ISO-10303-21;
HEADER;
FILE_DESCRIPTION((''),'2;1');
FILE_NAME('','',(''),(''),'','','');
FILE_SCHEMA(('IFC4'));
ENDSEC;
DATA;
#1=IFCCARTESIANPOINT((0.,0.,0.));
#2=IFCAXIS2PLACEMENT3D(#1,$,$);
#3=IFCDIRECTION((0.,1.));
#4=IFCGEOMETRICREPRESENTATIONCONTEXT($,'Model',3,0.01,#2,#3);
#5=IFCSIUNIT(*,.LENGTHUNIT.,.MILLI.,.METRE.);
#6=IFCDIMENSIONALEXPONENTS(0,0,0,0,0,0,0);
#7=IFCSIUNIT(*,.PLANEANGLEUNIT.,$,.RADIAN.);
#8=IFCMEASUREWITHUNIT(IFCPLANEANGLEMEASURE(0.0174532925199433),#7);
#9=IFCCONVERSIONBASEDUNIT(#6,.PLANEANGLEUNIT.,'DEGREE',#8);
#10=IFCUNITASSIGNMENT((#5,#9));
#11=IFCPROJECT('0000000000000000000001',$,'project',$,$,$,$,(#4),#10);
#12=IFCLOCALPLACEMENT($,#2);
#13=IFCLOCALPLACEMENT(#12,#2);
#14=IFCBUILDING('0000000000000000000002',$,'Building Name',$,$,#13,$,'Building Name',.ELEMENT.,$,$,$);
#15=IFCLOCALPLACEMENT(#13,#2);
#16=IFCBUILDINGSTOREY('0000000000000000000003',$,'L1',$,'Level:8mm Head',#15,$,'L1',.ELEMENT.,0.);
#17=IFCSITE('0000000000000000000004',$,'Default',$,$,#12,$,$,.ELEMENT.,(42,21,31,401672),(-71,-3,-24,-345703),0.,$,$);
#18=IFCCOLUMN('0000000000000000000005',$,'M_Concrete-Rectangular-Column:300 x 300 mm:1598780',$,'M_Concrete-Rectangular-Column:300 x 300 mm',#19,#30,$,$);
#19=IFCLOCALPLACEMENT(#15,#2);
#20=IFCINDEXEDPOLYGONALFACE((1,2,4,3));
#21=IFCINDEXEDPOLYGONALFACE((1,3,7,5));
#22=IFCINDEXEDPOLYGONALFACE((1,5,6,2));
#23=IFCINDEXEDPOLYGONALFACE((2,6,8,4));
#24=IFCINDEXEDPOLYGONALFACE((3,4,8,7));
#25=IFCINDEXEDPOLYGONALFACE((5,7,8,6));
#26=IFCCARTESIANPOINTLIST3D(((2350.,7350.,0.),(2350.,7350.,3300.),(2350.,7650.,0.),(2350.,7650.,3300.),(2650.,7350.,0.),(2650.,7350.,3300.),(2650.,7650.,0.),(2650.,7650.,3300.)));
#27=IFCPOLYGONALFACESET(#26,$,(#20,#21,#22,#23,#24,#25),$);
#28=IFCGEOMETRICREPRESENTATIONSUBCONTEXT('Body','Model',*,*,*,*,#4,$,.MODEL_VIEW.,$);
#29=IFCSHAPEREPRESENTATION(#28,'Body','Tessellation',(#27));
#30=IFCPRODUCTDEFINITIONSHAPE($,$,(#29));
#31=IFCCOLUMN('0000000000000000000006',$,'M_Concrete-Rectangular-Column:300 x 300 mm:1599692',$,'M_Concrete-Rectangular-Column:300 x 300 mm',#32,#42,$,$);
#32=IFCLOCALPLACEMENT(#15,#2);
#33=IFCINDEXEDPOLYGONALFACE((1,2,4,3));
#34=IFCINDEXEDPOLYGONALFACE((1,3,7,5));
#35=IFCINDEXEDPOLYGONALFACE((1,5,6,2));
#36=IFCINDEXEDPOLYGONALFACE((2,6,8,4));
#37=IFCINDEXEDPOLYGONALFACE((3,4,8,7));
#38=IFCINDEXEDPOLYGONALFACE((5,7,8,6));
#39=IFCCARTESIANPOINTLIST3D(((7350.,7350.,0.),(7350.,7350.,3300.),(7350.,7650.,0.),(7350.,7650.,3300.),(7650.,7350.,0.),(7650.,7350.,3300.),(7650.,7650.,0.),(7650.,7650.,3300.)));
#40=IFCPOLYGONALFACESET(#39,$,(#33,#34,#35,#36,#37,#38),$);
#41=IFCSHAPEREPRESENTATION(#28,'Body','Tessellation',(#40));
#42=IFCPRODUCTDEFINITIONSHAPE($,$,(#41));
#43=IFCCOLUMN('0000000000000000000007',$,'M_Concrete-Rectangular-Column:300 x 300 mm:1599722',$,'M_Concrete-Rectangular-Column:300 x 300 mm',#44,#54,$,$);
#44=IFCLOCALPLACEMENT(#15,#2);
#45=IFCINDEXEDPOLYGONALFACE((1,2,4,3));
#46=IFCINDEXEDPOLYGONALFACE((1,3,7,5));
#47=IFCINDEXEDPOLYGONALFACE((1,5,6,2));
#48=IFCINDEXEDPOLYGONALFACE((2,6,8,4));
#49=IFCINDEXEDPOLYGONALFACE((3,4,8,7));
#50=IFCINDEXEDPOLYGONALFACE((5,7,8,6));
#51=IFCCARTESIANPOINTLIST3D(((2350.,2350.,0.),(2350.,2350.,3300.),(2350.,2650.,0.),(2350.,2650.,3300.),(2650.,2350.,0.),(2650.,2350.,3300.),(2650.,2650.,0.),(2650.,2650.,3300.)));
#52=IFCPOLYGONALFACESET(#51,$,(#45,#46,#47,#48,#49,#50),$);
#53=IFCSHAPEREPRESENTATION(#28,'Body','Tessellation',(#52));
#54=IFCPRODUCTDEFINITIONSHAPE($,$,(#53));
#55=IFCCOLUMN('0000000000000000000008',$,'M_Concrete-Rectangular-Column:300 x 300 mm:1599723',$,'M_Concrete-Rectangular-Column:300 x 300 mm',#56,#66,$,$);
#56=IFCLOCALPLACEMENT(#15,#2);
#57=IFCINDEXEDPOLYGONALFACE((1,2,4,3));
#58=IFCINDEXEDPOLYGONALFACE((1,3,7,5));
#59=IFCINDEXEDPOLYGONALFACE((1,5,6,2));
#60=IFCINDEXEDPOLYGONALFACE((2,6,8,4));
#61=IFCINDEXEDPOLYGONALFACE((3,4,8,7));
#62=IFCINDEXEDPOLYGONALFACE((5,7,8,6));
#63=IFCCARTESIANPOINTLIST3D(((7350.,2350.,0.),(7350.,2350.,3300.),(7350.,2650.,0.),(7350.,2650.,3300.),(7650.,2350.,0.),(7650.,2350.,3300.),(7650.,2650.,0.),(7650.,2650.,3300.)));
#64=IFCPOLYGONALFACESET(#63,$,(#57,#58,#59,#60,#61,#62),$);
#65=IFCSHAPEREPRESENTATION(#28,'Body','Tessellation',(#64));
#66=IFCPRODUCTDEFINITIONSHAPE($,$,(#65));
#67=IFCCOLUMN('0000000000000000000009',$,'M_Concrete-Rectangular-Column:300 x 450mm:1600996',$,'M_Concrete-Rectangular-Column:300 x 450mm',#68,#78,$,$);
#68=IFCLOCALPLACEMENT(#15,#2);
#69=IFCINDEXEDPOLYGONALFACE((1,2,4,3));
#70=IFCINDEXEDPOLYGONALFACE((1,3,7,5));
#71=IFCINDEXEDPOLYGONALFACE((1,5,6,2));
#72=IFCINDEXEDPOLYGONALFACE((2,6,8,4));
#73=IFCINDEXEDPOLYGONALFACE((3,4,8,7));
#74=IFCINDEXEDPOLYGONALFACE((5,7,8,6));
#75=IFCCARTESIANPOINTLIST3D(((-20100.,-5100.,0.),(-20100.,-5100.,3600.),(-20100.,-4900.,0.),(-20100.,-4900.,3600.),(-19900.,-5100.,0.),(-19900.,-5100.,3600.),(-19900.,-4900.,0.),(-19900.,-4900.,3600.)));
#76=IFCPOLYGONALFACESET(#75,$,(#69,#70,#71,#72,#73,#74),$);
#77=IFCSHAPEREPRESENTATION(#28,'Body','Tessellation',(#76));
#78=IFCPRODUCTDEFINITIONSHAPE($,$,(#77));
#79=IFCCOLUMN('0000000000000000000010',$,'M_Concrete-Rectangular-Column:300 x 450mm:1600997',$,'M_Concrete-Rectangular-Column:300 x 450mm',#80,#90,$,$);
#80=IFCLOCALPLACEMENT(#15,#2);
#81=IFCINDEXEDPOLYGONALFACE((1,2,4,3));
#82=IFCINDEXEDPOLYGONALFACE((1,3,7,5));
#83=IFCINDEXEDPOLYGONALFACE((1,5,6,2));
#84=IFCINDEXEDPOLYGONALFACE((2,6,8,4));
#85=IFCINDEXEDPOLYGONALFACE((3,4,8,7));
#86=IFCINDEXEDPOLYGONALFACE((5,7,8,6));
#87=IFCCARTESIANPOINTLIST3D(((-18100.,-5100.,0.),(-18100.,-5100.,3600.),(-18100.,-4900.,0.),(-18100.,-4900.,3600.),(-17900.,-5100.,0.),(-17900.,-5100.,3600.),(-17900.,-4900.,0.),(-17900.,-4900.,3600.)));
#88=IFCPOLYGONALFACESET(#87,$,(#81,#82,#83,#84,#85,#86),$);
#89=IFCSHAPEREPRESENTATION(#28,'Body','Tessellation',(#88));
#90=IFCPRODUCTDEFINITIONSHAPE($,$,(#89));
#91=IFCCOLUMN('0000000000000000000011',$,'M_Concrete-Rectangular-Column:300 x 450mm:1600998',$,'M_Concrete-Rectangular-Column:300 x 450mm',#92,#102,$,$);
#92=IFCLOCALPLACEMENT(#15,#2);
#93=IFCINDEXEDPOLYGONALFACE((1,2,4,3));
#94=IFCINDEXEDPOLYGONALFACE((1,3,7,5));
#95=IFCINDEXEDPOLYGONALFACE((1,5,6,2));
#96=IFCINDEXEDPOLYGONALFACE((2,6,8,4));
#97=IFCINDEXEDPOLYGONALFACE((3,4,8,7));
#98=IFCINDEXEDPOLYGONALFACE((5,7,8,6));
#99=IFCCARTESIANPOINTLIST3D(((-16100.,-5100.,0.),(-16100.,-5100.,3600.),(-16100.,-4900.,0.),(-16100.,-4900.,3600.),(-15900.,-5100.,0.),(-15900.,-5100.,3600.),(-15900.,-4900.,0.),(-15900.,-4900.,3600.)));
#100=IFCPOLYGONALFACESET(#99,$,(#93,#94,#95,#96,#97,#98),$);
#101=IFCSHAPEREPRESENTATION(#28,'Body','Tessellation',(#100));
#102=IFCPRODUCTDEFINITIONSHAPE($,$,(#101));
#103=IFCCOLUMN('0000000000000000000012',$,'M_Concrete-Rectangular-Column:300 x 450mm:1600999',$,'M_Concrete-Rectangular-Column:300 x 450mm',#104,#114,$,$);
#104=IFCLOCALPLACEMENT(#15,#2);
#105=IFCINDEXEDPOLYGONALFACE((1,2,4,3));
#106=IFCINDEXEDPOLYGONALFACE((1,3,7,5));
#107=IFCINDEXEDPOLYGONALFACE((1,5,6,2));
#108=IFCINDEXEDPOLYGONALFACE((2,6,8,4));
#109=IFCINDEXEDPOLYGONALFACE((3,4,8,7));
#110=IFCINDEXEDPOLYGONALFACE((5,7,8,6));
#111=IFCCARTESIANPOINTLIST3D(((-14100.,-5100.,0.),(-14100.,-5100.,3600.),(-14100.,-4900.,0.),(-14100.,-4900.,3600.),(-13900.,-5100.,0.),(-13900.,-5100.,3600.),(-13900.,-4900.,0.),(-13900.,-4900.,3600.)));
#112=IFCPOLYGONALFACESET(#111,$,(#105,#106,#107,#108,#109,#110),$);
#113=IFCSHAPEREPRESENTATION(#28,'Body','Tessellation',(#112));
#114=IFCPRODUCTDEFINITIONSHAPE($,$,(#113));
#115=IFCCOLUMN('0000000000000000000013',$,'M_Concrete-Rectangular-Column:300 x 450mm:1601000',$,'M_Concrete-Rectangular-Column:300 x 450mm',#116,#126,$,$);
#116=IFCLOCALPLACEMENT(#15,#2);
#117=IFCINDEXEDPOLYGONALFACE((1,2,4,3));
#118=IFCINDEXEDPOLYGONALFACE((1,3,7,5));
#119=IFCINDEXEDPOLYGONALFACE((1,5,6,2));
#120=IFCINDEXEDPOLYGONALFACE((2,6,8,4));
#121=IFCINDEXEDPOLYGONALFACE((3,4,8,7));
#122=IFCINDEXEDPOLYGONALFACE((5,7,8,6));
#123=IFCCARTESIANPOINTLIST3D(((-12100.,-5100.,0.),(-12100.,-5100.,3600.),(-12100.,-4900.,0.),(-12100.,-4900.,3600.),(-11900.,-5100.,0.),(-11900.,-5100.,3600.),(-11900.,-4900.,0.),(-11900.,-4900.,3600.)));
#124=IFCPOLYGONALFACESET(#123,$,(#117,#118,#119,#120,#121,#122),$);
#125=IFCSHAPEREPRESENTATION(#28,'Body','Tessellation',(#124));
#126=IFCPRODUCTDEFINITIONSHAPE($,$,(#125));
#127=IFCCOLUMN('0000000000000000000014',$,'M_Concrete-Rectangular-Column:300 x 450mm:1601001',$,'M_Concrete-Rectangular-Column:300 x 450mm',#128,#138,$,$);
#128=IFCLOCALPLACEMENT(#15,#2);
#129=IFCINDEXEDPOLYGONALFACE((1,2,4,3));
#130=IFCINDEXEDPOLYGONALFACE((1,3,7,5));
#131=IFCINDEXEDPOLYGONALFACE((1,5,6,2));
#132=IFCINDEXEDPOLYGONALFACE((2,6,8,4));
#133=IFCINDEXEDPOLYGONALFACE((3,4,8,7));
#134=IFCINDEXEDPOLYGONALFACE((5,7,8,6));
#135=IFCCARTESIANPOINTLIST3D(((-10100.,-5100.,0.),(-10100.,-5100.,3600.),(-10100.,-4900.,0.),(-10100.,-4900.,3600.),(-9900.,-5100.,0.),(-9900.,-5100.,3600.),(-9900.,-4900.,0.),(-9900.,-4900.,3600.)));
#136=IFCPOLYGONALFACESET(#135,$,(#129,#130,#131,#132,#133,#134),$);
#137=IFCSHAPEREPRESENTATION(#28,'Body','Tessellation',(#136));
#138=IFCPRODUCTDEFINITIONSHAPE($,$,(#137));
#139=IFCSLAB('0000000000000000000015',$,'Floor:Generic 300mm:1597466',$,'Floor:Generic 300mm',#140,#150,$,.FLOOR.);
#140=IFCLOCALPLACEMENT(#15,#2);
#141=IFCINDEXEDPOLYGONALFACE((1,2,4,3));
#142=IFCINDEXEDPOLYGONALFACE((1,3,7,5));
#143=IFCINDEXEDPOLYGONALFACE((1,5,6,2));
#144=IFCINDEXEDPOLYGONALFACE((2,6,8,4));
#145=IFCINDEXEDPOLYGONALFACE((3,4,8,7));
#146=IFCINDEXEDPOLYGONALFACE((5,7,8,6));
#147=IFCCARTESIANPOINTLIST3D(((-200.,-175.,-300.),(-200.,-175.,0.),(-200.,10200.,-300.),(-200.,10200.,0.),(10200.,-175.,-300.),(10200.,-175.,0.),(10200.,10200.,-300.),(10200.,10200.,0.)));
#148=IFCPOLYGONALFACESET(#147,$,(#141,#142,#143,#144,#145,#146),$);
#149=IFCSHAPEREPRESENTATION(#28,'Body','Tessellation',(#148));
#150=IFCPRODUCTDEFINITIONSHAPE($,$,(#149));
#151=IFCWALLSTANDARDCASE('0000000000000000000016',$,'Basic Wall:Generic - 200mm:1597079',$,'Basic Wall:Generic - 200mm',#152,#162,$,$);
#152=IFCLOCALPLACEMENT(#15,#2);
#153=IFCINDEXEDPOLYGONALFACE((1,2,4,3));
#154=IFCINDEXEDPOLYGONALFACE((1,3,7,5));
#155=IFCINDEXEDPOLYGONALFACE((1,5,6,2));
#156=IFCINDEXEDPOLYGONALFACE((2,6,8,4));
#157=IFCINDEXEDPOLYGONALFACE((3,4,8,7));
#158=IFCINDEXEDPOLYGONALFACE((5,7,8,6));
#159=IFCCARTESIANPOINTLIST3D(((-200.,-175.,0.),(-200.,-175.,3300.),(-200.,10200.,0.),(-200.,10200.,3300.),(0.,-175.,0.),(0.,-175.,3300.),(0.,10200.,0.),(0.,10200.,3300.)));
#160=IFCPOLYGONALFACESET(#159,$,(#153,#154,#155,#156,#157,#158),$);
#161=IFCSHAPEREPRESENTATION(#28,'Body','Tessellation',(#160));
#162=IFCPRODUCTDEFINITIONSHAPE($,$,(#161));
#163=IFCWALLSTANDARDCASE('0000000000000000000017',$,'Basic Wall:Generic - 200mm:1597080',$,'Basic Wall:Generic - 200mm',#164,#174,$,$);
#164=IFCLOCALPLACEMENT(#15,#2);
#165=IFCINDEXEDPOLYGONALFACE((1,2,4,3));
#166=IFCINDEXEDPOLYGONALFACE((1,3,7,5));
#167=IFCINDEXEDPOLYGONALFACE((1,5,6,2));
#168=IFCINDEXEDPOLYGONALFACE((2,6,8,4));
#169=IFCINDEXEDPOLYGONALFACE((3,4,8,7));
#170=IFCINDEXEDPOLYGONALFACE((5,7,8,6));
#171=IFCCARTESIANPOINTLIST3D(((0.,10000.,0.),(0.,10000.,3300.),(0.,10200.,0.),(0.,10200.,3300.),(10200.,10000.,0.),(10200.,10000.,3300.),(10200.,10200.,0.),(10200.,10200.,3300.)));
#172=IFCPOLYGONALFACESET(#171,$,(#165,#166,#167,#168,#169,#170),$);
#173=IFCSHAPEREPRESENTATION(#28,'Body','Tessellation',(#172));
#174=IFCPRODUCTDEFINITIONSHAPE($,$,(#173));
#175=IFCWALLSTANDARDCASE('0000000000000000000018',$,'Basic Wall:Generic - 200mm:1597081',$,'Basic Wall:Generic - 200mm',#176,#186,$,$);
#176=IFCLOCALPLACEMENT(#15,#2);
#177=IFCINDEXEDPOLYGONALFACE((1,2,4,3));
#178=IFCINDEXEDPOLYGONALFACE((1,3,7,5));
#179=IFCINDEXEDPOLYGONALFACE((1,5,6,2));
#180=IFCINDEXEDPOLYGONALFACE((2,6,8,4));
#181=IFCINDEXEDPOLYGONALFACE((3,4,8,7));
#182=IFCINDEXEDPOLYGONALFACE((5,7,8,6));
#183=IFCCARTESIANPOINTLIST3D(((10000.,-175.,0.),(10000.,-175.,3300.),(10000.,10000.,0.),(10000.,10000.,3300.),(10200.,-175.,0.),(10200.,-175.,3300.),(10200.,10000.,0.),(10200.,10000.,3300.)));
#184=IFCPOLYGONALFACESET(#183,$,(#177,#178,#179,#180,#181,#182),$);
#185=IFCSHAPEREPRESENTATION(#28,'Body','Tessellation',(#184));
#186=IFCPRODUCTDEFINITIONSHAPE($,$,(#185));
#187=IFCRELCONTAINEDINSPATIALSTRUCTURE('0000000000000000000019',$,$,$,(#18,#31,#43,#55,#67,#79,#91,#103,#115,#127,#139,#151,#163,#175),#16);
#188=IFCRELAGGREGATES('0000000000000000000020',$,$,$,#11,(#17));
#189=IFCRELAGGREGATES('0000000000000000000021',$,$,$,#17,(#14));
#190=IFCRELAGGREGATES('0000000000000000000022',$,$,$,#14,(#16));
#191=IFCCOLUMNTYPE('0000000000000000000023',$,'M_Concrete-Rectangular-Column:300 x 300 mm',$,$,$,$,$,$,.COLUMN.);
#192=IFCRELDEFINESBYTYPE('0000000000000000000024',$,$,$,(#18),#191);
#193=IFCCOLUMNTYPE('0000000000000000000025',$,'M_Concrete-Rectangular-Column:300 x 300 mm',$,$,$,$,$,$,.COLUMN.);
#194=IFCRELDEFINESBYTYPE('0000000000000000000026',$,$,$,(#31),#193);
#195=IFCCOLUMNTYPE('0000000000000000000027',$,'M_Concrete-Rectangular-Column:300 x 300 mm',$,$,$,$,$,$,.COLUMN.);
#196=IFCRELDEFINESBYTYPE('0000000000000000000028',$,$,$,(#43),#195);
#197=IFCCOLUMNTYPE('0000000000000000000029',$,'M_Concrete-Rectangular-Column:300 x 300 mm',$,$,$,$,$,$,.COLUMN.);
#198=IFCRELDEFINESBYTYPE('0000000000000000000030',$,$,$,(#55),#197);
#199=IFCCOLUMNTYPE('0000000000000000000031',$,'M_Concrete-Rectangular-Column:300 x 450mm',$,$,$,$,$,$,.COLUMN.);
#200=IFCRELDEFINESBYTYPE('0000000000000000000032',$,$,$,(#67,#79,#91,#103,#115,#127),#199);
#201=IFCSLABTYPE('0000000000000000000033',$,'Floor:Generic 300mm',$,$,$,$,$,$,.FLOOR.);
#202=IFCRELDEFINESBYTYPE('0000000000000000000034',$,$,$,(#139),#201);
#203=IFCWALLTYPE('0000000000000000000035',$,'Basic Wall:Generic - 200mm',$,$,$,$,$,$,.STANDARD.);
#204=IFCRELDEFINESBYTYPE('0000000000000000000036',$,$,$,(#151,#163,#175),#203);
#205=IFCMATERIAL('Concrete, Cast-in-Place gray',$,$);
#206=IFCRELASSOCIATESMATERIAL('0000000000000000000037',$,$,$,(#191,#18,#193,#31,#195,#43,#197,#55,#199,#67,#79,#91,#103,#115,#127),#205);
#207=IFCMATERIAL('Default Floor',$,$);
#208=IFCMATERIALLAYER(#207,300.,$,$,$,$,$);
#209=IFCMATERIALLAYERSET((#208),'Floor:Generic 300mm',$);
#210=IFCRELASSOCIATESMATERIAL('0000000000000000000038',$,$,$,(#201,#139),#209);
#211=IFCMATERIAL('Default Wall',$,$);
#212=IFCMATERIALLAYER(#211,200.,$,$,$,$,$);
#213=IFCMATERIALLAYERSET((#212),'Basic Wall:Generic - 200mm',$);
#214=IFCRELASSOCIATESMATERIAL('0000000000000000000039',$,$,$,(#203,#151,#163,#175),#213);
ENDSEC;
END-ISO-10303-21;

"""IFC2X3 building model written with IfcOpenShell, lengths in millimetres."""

from ifc_helpers import new_model, entity, si_unit, converted_unit, direction, frame, frame_2d, origin, origin_2d_with_axis, place, context, subcontext, project, spatial, rectangle, extrude, source, transform, mapped, material, layer, layer_set, layer_usage, type_object, type_shapes, element, save


model = new_model("IFC2X3")

# Units and contexts
model_context = context("Model", 3, precision=0.01, world=origin(), true_north=direction((0.0, 1.0)))
body_context = subcontext(model_context, "Body", "Model", "MODEL_VIEW")
ifc_project = project(units=[si_unit("LENGTHUNIT", "METRE", prefix="MILLI"), converted_unit("PLANEANGLEUNIT", "DEGREE", entity("IfcPlaneAngleMeasure", 0.0174532925199433), si_unit("PLANEANGLEUNIT", "RADIAN"), dimensions=[0, 0, 0, 0, 0, 0, 0])], contexts=[model_context])

# Site, building, storey
site_placement = place(None, origin())
site = spatial("IfcSite", under=ifc_project, at=site_placement, Name="Default", CompositionType="ELEMENT", RefLatitude=(42, 21, 31, 401672), RefLongitude=(-71, -3, -24, -345703), RefElevation=0.0)
building_placement = place(site_placement, origin())
building = spatial("IfcBuilding", under=site, at=building_placement, Name="Building Name", LongName="Building Name", CompositionType="ELEMENT")
storey_placement = place(building_placement, origin())
storey = spatial("IfcBuildingStorey", under=building, at=storey_placement, Name="L1", ObjectType="Level:8mm Head", LongName="L1", CompositionType="ELEMENT", Elevation=0.0)

# Columns
ifc_material_1 = material(Name="Concrete, Cast-in-Place gray")
column_type_1 = type_object("IfcColumnType", Name="M_Concrete-Rectangular-Column:300 x 300 mm", PredefinedType="COLUMN", material=ifc_material_1)
shared_shape_1 = source(origin(), body_context, "Body", "SweptSolid", [
    extrude(rectangle(XDim=300.0, YDim=300.0, at=origin_2d_with_axis()), frame((2500.0, 7500.0, 0.0)), (0.0, 0.0, 1.0), 3300.0),
])
type_shapes(column_type_1, [shared_shape_1])
column_1_placement = place(storey_placement, origin())
element("IfcColumn", 1, at=column_1_placement, inside=storey, type_object=column_type_1, material=ifc_material_1, Name="M_Concrete-Rectangular-Column:300 x 300 mm:1598780", ObjectType="M_Concrete-Rectangular-Column:300 x 300 mm", context=body_context, shape_type="MappedRepresentation", body=[
    mapped(shared_shape_1, transform((0.0, 0.0, 0.0), scale=1.0)),
])
column_type_2 = type_object("IfcColumnType", Name="M_Concrete-Rectangular-Column:300 x 300 mm", PredefinedType="COLUMN", material=ifc_material_1)
shared_shape_2 = source(origin(), body_context, "Body", "SweptSolid", [
    extrude(rectangle(XDim=300.0, YDim=300.0, at=origin_2d_with_axis()), frame((7500.0, 7500.0, 0.0)), (0.0, 0.0, 1.0), 3300.0),
])
type_shapes(column_type_2, [shared_shape_2])
column_2_placement = place(storey_placement, origin())
element("IfcColumn", 2, at=column_2_placement, inside=storey, type_object=column_type_2, material=ifc_material_1, Name="M_Concrete-Rectangular-Column:300 x 300 mm:1599692", ObjectType="M_Concrete-Rectangular-Column:300 x 300 mm", context=body_context, shape_type="MappedRepresentation", body=[
    mapped(shared_shape_2, transform((0.0, 0.0, 0.0), scale=1.0)),
])
column_type_3 = type_object("IfcColumnType", Name="M_Concrete-Rectangular-Column:300 x 300 mm", PredefinedType="COLUMN", material=ifc_material_1)
shared_shape_3 = source(origin(), body_context, "Body", "SweptSolid", [
    extrude(rectangle(XDim=300.0, YDim=300.0, at=origin_2d_with_axis()), frame((2500.0, 2500.0, 0.0)), (0.0, 0.0, 1.0), 3300.0),
])
type_shapes(column_type_3, [shared_shape_3])
column_3_placement = place(storey_placement, origin())
element("IfcColumn", 3, at=column_3_placement, inside=storey, type_object=column_type_3, material=ifc_material_1, Name="M_Concrete-Rectangular-Column:300 x 300 mm:1599722", ObjectType="M_Concrete-Rectangular-Column:300 x 300 mm", context=body_context, shape_type="MappedRepresentation", body=[
    mapped(shared_shape_3, transform((0.0, 0.0, 0.0), scale=1.0)),
])
column_type_4 = type_object("IfcColumnType", Name="M_Concrete-Rectangular-Column:300 x 300 mm", PredefinedType="COLUMN", material=ifc_material_1)
shared_shape_4 = source(origin(), body_context, "Body", "SweptSolid", [
    extrude(rectangle(XDim=300.0, YDim=300.0, at=origin_2d_with_axis()), frame((7500.0, 2500.0, 0.0)), (0.0, 0.0, 1.0), 3300.0),
])
type_shapes(column_type_4, [shared_shape_4])
column_4_placement = place(storey_placement, origin())
element("IfcColumn", 4, at=column_4_placement, inside=storey, type_object=column_type_4, material=ifc_material_1, Name="M_Concrete-Rectangular-Column:300 x 300 mm:1599723", ObjectType="M_Concrete-Rectangular-Column:300 x 300 mm", context=body_context, shape_type="MappedRepresentation", body=[
    mapped(shared_shape_4, transform((0.0, 0.0, 0.0), scale=1.0)),
])
column_type_5 = type_object("IfcColumnType", Name="M_Concrete-Rectangular-Column:300 x 450mm", PredefinedType="COLUMN", material=ifc_material_1)
shared_shape_5 = source(origin(), body_context, "Body", "SweptSolid", [
    extrude(rectangle(XDim=200.0, YDim=200.0, at=origin_2d_with_axis()), frame((0.0, 0.0, 0.0), z_axis=(0.0, 0.0, 1.0), x_axis=(-1.0, 0.0, 0.0)), (0.0, 0.0, 1.0), 3600.0),
])
type_shapes(column_type_5, [shared_shape_5])
for number, where, z_axis, x_axis, name in (
    (5, (-20000.0, -5000.0, 0.0), (0.0, 0.0, 1.0), (0.0, -1.0, 0.0), "M_Concrete-Rectangular-Column:300 x 450mm:1600996"),
    (6, (-18000.0, -5000.0, 0.0), (0.0, 0.0, 1.0), (0.0, -1.0, 0.0), "M_Concrete-Rectangular-Column:300 x 450mm:1600997"),
    (7, (-16000.0, -5000.0, 0.0), (0.0, 0.0, 1.0), (0.0, -1.0, 0.0), "M_Concrete-Rectangular-Column:300 x 450mm:1600998"),
    (8, (-14000.0, -5000.0, 0.0), (0.0, 0.0, 1.0), (0.0, -1.0, 0.0), "M_Concrete-Rectangular-Column:300 x 450mm:1600999"),
    (9, (-12000.0, -5000.0, 0.0), (0.0, 0.0, 1.0), (0.0, -1.0, 0.0), "M_Concrete-Rectangular-Column:300 x 450mm:1601000"),
    (10, (-10000.0, -5000.0, 0.0), (0.0, 0.0, 1.0), (0.0, -1.0, 0.0), "M_Concrete-Rectangular-Column:300 x 450mm:1601001"),
):
    element("IfcColumn", number, at=place(storey_placement, frame(where, z_axis=z_axis, x_axis=x_axis)), inside=storey, type_object=column_type_5, material=ifc_material_1, Name=name, ObjectType="M_Concrete-Rectangular-Column:300 x 450mm", context=body_context, shape_type="MappedRepresentation", body=[
        mapped(shared_shape_5, transform((0.0, 0.0, 0.0), scale=1.0)),
    ])

# Slab
ifc_material_2 = material(Name="Default Floor")
ifc_layer_1 = layer(ifc_material_2, 300.0)
ifc_layer_set_1 = layer_set([ifc_layer_1], Name="Floor:Generic 300mm")
ifc_layer_usage_1 = layer_usage(ifc_layer_set_1, "AXIS3", "POSITIVE", 0.0)
slab_type = type_object("IfcSlabType", Name="Floor:Generic 300mm", PredefinedType="FLOOR", material=ifc_layer_set_1)
slab_placement = place(storey_placement, origin())
element("IfcSlab", 11, at=slab_placement, inside=storey, type_object=slab_type, material=ifc_layer_usage_1, Name="Floor:Generic 300mm:1597466", ObjectType="Floor:Generic 300mm", PredefinedType="FLOOR", context=body_context, shape_type="SweptSolid", body=[
    extrude(rectangle(XDim=10375.0, YDim=10400.0, at=origin_2d_with_axis()), frame((5000.0, 5012.5, 0.0), z_axis=(0.0, 0.0, -1.0), x_axis=(0.0, 1.0, 0.0)), (0.0, 0.0, 1.0), 300.0),
])

# Walls
ifc_material_3 = material(Name="Default Wall")
ifc_layer_2 = layer(ifc_material_3, 200.0)
ifc_layer_set_2 = layer_set([ifc_layer_2], Name="Basic Wall:Generic - 200mm")
ifc_layer_usage_2 = layer_usage(ifc_layer_set_2, "AXIS2", "NEGATIVE", 100.0)
wall_type_1 = type_object("IfcWallType", Name="Basic Wall:Generic - 200mm", PredefinedType="STANDARD", material=ifc_layer_set_2)
wall_1_placement = place(storey_placement, frame((-100.0, 10200.0, 0.0), z_axis=(0.0, 0.0, 1.0), x_axis=(0.0, -1.0, 0.0)))
element("IfcWallStandardCase", 12, at=wall_1_placement, inside=storey, type_object=wall_type_1, material=ifc_layer_usage_2, Name="Basic Wall:Generic - 200mm:1597079", ObjectType="Basic Wall:Generic - 200mm", context=body_context, shape_type="SweptSolid", body=[
    extrude(rectangle(XDim=10375.0, YDim=200.0, at=frame_2d((5187.5, 0.0), x_axis=(-1.0, 0.0))), origin(), (0.0, 0.0, 1.0), 3300.0),
])
ifc_layer_usage_3 = layer_usage(ifc_layer_set_2, "AXIS2", "NEGATIVE", 100.0)
wall_2_placement = place(storey_placement, frame((10200.0, 10100.0, 0.0), z_axis=(0.0, 0.0, 1.0), x_axis=(-1.0, 0.0, 0.0)))
element("IfcWallStandardCase", 13, at=wall_2_placement, inside=storey, type_object=wall_type_1, material=ifc_layer_usage_3, Name="Basic Wall:Generic - 200mm:1597080", ObjectType="Basic Wall:Generic - 200mm", context=body_context, shape_type="SweptSolid", body=[
    extrude(rectangle(XDim=10200.0, YDim=200.0, at=frame_2d((5100.0, 0.0), x_axis=(-1.0, 0.0))), origin(), (0.0, 0.0, 1.0), 3300.0),
])
ifc_layer_usage_4 = layer_usage(ifc_layer_set_2, "AXIS2", "NEGATIVE", 100.0)
wall_3_placement = place(storey_placement, frame((10100.0, -175.0, 0.0), z_axis=(0.0, 0.0, 1.0), x_axis=(0.0, 1.0, 0.0)))
element("IfcWallStandardCase", 14, at=wall_3_placement, inside=storey, type_object=wall_type_1, material=ifc_layer_usage_4, Name="Basic Wall:Generic - 200mm:1597081", ObjectType="Basic Wall:Generic - 200mm", context=body_context, shape_type="SweptSolid", body=[
    extrude(rectangle(XDim=10175.0, YDim=200.0, at=frame_2d((5087.5, 0.0), x_axis=(-1.0, 0.0))), origin(), (0.0, 0.0, 1.0), 3300.0),
])

save(model, "model.ifc")
